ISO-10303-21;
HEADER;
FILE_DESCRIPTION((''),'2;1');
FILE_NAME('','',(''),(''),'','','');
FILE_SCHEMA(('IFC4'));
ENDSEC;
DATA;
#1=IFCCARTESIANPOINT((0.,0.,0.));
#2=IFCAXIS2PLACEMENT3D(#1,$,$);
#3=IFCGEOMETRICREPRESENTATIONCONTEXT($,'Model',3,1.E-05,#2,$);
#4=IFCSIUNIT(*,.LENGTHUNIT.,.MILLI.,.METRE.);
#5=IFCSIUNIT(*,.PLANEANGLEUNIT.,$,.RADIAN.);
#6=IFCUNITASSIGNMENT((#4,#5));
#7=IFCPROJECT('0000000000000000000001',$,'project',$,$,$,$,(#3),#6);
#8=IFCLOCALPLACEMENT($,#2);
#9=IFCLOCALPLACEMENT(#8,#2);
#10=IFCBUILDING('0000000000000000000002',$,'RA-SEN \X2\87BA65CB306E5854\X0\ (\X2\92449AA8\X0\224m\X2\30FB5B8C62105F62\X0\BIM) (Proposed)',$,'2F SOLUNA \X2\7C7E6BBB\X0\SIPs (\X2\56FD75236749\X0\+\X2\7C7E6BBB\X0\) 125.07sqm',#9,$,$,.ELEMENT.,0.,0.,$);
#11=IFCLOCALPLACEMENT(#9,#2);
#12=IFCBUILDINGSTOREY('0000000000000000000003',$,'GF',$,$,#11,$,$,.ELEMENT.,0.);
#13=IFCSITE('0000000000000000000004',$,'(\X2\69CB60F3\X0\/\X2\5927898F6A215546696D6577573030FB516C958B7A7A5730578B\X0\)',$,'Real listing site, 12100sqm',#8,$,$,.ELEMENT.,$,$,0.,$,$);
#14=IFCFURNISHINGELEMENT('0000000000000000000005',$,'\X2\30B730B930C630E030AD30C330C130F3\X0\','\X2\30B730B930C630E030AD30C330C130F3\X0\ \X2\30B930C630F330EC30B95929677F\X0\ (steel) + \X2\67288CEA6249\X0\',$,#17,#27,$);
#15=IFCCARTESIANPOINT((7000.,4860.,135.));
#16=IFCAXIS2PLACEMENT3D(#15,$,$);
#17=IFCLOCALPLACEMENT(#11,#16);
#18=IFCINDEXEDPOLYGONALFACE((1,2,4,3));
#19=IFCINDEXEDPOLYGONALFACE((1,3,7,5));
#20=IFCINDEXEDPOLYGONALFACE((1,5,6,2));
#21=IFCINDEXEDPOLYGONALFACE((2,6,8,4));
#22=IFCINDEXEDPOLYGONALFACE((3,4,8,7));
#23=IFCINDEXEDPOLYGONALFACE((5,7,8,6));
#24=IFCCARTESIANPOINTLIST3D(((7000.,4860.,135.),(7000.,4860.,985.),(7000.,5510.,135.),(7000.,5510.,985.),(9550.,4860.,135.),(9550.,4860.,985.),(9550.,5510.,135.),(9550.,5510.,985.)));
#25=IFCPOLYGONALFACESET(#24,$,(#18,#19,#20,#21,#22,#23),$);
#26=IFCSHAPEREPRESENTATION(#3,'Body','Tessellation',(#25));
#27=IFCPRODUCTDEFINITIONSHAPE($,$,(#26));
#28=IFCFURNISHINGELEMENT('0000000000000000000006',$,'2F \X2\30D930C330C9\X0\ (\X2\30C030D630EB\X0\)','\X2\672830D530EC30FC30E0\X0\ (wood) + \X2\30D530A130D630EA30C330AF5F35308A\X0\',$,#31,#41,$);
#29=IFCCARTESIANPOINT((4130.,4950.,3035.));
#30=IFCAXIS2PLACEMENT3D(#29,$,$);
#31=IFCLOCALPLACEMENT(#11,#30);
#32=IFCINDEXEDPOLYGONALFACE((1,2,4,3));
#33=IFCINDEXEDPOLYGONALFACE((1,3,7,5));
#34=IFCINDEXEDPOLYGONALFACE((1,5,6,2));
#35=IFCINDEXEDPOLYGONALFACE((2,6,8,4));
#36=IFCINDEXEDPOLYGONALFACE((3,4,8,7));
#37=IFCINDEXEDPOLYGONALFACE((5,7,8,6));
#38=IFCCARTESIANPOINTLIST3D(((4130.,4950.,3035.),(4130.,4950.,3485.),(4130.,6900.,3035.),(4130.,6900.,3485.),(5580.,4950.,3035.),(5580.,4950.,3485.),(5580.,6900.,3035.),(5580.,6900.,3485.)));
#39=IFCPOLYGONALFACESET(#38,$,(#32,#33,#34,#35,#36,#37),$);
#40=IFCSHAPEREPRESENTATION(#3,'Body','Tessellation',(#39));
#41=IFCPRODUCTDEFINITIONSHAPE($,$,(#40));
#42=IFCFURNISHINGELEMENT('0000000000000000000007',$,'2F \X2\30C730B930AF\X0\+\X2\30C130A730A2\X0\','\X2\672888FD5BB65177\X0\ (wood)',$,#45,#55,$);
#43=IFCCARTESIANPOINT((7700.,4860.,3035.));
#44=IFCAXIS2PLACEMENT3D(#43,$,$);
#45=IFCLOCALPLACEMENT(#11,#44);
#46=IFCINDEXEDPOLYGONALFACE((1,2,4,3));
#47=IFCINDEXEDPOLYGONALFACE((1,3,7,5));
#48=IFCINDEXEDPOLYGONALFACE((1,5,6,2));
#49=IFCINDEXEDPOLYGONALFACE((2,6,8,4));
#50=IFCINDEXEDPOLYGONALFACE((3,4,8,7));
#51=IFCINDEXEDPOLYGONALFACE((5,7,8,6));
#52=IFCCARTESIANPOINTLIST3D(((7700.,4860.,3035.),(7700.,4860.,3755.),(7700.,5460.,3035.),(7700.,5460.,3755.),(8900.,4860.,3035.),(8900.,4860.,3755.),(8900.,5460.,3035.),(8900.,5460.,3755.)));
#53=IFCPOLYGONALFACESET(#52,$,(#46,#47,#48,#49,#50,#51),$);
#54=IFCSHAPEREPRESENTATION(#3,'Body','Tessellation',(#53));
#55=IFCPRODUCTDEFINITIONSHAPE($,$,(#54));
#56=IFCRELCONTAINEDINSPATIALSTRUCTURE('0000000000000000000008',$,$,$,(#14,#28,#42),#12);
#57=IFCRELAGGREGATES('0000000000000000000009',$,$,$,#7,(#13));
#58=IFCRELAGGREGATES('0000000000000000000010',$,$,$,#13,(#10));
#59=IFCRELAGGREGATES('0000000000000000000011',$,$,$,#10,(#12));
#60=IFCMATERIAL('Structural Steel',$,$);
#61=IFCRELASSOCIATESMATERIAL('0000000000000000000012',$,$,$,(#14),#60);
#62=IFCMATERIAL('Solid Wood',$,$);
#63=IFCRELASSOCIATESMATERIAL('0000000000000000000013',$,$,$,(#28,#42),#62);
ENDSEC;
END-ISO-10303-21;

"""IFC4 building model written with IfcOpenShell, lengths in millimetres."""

from ifc_helpers import new_model, si_unit, frame, frame_2d, origin, place, context, project, spatial, rectangle, extrude, material, element, save


model = new_model("IFC4")

# Units and contexts
model_context = context("Model", 3, precision=1e-05, world=origin())
ifc_project = project(units=[si_unit("LENGTHUNIT", "METRE", prefix="MILLI"), si_unit("PLANEANGLEUNIT", "RADIAN")], contexts=[model_context])

# Site, building, storey
site_placement = place(None, origin())
site = spatial("IfcSite", under=ifc_project, at=site_placement, Name="(構想/大規模商業敷地・公開空地型)", ObjectType="Real listing site, 12100sqm", CompositionType="ELEMENT", RefElevation=0.0)
building_placement = place(site_placement, origin())
building = spatial("IfcBuilding", under=site, at=building_placement, Name="RA-SEN 螺旋の塔 (鉄骨224m・完成形BIM) (Proposed)", ObjectType="2F SOLUNA 籾殻SIPs (国産杉+籾殻) 125.07sqm", CompositionType="ELEMENT", ElevationOfRefHeight=0.0, ElevationOfTerrain=0.0)
storey_placement = place(building_placement, origin())
storey = spatial("IfcBuildingStorey", under=building, at=storey_placement, Name="GF", CompositionType="ELEMENT", Elevation=0.0)

# Shared definitions
ifc_material_1 = material(Name="Solid Wood")

# Furnishing elements
ifc_material_2 = material(Name="Structural Steel")
furnishing_1_placement = place(storey_placement, frame((7000.0, 4860.0, 135.0)))
element("IfcFurnishingElement", 1, at=furnishing_1_placement, inside=storey, material=ifc_material_2, Name="システムキッチン", Description="システムキッチン ステンレス天板 (steel) + 木質扉", context=model_context, shape_type="SweptSolid", body=[
    extrude(rectangle(XDim=2550.0, YDim=650.0, at=frame_2d((1275.0, 325.0))), frame((7000.0, 4860.0, 135.0)), (0.0, 0.0, 1.0), 850.0),
])
furnishing_2_placement = place(storey_placement, frame((4130.0, 4950.0, 3035.0)))
element("IfcFurnishingElement", 2, at=furnishing_2_placement, inside=storey, material=ifc_material_1, Name="2F ベッド (ダブル)", Description="木フレーム (wood) + ファブリック張り", context=model_context, shape_type="SweptSolid", body=[
    extrude(rectangle(XDim=1450.0, YDim=1950.0, at=frame_2d((725.0, 975.0))), frame((4130.0, 4950.0, 3035.0)), (0.0, 0.0, 1.0), 450.0),
])
furnishing_3_placement = place(storey_placement, frame((7700.0, 4860.0, 3035.0)))
element("IfcFurnishingElement", 3, at=furnishing_3_placement, inside=storey, material=ifc_material_1, Name="2F デスク+チェア", Description="木製家具 (wood)", context=model_context, shape_type="SweptSolid", body=[
    extrude(rectangle(XDim=1200.0, YDim=600.0, at=frame_2d((600.0, 300.0))), frame((7700.0, 4860.0, 3035.0)), (0.0, 0.0, 1.0), 720.0),
])

save(model, "model.ifc")
